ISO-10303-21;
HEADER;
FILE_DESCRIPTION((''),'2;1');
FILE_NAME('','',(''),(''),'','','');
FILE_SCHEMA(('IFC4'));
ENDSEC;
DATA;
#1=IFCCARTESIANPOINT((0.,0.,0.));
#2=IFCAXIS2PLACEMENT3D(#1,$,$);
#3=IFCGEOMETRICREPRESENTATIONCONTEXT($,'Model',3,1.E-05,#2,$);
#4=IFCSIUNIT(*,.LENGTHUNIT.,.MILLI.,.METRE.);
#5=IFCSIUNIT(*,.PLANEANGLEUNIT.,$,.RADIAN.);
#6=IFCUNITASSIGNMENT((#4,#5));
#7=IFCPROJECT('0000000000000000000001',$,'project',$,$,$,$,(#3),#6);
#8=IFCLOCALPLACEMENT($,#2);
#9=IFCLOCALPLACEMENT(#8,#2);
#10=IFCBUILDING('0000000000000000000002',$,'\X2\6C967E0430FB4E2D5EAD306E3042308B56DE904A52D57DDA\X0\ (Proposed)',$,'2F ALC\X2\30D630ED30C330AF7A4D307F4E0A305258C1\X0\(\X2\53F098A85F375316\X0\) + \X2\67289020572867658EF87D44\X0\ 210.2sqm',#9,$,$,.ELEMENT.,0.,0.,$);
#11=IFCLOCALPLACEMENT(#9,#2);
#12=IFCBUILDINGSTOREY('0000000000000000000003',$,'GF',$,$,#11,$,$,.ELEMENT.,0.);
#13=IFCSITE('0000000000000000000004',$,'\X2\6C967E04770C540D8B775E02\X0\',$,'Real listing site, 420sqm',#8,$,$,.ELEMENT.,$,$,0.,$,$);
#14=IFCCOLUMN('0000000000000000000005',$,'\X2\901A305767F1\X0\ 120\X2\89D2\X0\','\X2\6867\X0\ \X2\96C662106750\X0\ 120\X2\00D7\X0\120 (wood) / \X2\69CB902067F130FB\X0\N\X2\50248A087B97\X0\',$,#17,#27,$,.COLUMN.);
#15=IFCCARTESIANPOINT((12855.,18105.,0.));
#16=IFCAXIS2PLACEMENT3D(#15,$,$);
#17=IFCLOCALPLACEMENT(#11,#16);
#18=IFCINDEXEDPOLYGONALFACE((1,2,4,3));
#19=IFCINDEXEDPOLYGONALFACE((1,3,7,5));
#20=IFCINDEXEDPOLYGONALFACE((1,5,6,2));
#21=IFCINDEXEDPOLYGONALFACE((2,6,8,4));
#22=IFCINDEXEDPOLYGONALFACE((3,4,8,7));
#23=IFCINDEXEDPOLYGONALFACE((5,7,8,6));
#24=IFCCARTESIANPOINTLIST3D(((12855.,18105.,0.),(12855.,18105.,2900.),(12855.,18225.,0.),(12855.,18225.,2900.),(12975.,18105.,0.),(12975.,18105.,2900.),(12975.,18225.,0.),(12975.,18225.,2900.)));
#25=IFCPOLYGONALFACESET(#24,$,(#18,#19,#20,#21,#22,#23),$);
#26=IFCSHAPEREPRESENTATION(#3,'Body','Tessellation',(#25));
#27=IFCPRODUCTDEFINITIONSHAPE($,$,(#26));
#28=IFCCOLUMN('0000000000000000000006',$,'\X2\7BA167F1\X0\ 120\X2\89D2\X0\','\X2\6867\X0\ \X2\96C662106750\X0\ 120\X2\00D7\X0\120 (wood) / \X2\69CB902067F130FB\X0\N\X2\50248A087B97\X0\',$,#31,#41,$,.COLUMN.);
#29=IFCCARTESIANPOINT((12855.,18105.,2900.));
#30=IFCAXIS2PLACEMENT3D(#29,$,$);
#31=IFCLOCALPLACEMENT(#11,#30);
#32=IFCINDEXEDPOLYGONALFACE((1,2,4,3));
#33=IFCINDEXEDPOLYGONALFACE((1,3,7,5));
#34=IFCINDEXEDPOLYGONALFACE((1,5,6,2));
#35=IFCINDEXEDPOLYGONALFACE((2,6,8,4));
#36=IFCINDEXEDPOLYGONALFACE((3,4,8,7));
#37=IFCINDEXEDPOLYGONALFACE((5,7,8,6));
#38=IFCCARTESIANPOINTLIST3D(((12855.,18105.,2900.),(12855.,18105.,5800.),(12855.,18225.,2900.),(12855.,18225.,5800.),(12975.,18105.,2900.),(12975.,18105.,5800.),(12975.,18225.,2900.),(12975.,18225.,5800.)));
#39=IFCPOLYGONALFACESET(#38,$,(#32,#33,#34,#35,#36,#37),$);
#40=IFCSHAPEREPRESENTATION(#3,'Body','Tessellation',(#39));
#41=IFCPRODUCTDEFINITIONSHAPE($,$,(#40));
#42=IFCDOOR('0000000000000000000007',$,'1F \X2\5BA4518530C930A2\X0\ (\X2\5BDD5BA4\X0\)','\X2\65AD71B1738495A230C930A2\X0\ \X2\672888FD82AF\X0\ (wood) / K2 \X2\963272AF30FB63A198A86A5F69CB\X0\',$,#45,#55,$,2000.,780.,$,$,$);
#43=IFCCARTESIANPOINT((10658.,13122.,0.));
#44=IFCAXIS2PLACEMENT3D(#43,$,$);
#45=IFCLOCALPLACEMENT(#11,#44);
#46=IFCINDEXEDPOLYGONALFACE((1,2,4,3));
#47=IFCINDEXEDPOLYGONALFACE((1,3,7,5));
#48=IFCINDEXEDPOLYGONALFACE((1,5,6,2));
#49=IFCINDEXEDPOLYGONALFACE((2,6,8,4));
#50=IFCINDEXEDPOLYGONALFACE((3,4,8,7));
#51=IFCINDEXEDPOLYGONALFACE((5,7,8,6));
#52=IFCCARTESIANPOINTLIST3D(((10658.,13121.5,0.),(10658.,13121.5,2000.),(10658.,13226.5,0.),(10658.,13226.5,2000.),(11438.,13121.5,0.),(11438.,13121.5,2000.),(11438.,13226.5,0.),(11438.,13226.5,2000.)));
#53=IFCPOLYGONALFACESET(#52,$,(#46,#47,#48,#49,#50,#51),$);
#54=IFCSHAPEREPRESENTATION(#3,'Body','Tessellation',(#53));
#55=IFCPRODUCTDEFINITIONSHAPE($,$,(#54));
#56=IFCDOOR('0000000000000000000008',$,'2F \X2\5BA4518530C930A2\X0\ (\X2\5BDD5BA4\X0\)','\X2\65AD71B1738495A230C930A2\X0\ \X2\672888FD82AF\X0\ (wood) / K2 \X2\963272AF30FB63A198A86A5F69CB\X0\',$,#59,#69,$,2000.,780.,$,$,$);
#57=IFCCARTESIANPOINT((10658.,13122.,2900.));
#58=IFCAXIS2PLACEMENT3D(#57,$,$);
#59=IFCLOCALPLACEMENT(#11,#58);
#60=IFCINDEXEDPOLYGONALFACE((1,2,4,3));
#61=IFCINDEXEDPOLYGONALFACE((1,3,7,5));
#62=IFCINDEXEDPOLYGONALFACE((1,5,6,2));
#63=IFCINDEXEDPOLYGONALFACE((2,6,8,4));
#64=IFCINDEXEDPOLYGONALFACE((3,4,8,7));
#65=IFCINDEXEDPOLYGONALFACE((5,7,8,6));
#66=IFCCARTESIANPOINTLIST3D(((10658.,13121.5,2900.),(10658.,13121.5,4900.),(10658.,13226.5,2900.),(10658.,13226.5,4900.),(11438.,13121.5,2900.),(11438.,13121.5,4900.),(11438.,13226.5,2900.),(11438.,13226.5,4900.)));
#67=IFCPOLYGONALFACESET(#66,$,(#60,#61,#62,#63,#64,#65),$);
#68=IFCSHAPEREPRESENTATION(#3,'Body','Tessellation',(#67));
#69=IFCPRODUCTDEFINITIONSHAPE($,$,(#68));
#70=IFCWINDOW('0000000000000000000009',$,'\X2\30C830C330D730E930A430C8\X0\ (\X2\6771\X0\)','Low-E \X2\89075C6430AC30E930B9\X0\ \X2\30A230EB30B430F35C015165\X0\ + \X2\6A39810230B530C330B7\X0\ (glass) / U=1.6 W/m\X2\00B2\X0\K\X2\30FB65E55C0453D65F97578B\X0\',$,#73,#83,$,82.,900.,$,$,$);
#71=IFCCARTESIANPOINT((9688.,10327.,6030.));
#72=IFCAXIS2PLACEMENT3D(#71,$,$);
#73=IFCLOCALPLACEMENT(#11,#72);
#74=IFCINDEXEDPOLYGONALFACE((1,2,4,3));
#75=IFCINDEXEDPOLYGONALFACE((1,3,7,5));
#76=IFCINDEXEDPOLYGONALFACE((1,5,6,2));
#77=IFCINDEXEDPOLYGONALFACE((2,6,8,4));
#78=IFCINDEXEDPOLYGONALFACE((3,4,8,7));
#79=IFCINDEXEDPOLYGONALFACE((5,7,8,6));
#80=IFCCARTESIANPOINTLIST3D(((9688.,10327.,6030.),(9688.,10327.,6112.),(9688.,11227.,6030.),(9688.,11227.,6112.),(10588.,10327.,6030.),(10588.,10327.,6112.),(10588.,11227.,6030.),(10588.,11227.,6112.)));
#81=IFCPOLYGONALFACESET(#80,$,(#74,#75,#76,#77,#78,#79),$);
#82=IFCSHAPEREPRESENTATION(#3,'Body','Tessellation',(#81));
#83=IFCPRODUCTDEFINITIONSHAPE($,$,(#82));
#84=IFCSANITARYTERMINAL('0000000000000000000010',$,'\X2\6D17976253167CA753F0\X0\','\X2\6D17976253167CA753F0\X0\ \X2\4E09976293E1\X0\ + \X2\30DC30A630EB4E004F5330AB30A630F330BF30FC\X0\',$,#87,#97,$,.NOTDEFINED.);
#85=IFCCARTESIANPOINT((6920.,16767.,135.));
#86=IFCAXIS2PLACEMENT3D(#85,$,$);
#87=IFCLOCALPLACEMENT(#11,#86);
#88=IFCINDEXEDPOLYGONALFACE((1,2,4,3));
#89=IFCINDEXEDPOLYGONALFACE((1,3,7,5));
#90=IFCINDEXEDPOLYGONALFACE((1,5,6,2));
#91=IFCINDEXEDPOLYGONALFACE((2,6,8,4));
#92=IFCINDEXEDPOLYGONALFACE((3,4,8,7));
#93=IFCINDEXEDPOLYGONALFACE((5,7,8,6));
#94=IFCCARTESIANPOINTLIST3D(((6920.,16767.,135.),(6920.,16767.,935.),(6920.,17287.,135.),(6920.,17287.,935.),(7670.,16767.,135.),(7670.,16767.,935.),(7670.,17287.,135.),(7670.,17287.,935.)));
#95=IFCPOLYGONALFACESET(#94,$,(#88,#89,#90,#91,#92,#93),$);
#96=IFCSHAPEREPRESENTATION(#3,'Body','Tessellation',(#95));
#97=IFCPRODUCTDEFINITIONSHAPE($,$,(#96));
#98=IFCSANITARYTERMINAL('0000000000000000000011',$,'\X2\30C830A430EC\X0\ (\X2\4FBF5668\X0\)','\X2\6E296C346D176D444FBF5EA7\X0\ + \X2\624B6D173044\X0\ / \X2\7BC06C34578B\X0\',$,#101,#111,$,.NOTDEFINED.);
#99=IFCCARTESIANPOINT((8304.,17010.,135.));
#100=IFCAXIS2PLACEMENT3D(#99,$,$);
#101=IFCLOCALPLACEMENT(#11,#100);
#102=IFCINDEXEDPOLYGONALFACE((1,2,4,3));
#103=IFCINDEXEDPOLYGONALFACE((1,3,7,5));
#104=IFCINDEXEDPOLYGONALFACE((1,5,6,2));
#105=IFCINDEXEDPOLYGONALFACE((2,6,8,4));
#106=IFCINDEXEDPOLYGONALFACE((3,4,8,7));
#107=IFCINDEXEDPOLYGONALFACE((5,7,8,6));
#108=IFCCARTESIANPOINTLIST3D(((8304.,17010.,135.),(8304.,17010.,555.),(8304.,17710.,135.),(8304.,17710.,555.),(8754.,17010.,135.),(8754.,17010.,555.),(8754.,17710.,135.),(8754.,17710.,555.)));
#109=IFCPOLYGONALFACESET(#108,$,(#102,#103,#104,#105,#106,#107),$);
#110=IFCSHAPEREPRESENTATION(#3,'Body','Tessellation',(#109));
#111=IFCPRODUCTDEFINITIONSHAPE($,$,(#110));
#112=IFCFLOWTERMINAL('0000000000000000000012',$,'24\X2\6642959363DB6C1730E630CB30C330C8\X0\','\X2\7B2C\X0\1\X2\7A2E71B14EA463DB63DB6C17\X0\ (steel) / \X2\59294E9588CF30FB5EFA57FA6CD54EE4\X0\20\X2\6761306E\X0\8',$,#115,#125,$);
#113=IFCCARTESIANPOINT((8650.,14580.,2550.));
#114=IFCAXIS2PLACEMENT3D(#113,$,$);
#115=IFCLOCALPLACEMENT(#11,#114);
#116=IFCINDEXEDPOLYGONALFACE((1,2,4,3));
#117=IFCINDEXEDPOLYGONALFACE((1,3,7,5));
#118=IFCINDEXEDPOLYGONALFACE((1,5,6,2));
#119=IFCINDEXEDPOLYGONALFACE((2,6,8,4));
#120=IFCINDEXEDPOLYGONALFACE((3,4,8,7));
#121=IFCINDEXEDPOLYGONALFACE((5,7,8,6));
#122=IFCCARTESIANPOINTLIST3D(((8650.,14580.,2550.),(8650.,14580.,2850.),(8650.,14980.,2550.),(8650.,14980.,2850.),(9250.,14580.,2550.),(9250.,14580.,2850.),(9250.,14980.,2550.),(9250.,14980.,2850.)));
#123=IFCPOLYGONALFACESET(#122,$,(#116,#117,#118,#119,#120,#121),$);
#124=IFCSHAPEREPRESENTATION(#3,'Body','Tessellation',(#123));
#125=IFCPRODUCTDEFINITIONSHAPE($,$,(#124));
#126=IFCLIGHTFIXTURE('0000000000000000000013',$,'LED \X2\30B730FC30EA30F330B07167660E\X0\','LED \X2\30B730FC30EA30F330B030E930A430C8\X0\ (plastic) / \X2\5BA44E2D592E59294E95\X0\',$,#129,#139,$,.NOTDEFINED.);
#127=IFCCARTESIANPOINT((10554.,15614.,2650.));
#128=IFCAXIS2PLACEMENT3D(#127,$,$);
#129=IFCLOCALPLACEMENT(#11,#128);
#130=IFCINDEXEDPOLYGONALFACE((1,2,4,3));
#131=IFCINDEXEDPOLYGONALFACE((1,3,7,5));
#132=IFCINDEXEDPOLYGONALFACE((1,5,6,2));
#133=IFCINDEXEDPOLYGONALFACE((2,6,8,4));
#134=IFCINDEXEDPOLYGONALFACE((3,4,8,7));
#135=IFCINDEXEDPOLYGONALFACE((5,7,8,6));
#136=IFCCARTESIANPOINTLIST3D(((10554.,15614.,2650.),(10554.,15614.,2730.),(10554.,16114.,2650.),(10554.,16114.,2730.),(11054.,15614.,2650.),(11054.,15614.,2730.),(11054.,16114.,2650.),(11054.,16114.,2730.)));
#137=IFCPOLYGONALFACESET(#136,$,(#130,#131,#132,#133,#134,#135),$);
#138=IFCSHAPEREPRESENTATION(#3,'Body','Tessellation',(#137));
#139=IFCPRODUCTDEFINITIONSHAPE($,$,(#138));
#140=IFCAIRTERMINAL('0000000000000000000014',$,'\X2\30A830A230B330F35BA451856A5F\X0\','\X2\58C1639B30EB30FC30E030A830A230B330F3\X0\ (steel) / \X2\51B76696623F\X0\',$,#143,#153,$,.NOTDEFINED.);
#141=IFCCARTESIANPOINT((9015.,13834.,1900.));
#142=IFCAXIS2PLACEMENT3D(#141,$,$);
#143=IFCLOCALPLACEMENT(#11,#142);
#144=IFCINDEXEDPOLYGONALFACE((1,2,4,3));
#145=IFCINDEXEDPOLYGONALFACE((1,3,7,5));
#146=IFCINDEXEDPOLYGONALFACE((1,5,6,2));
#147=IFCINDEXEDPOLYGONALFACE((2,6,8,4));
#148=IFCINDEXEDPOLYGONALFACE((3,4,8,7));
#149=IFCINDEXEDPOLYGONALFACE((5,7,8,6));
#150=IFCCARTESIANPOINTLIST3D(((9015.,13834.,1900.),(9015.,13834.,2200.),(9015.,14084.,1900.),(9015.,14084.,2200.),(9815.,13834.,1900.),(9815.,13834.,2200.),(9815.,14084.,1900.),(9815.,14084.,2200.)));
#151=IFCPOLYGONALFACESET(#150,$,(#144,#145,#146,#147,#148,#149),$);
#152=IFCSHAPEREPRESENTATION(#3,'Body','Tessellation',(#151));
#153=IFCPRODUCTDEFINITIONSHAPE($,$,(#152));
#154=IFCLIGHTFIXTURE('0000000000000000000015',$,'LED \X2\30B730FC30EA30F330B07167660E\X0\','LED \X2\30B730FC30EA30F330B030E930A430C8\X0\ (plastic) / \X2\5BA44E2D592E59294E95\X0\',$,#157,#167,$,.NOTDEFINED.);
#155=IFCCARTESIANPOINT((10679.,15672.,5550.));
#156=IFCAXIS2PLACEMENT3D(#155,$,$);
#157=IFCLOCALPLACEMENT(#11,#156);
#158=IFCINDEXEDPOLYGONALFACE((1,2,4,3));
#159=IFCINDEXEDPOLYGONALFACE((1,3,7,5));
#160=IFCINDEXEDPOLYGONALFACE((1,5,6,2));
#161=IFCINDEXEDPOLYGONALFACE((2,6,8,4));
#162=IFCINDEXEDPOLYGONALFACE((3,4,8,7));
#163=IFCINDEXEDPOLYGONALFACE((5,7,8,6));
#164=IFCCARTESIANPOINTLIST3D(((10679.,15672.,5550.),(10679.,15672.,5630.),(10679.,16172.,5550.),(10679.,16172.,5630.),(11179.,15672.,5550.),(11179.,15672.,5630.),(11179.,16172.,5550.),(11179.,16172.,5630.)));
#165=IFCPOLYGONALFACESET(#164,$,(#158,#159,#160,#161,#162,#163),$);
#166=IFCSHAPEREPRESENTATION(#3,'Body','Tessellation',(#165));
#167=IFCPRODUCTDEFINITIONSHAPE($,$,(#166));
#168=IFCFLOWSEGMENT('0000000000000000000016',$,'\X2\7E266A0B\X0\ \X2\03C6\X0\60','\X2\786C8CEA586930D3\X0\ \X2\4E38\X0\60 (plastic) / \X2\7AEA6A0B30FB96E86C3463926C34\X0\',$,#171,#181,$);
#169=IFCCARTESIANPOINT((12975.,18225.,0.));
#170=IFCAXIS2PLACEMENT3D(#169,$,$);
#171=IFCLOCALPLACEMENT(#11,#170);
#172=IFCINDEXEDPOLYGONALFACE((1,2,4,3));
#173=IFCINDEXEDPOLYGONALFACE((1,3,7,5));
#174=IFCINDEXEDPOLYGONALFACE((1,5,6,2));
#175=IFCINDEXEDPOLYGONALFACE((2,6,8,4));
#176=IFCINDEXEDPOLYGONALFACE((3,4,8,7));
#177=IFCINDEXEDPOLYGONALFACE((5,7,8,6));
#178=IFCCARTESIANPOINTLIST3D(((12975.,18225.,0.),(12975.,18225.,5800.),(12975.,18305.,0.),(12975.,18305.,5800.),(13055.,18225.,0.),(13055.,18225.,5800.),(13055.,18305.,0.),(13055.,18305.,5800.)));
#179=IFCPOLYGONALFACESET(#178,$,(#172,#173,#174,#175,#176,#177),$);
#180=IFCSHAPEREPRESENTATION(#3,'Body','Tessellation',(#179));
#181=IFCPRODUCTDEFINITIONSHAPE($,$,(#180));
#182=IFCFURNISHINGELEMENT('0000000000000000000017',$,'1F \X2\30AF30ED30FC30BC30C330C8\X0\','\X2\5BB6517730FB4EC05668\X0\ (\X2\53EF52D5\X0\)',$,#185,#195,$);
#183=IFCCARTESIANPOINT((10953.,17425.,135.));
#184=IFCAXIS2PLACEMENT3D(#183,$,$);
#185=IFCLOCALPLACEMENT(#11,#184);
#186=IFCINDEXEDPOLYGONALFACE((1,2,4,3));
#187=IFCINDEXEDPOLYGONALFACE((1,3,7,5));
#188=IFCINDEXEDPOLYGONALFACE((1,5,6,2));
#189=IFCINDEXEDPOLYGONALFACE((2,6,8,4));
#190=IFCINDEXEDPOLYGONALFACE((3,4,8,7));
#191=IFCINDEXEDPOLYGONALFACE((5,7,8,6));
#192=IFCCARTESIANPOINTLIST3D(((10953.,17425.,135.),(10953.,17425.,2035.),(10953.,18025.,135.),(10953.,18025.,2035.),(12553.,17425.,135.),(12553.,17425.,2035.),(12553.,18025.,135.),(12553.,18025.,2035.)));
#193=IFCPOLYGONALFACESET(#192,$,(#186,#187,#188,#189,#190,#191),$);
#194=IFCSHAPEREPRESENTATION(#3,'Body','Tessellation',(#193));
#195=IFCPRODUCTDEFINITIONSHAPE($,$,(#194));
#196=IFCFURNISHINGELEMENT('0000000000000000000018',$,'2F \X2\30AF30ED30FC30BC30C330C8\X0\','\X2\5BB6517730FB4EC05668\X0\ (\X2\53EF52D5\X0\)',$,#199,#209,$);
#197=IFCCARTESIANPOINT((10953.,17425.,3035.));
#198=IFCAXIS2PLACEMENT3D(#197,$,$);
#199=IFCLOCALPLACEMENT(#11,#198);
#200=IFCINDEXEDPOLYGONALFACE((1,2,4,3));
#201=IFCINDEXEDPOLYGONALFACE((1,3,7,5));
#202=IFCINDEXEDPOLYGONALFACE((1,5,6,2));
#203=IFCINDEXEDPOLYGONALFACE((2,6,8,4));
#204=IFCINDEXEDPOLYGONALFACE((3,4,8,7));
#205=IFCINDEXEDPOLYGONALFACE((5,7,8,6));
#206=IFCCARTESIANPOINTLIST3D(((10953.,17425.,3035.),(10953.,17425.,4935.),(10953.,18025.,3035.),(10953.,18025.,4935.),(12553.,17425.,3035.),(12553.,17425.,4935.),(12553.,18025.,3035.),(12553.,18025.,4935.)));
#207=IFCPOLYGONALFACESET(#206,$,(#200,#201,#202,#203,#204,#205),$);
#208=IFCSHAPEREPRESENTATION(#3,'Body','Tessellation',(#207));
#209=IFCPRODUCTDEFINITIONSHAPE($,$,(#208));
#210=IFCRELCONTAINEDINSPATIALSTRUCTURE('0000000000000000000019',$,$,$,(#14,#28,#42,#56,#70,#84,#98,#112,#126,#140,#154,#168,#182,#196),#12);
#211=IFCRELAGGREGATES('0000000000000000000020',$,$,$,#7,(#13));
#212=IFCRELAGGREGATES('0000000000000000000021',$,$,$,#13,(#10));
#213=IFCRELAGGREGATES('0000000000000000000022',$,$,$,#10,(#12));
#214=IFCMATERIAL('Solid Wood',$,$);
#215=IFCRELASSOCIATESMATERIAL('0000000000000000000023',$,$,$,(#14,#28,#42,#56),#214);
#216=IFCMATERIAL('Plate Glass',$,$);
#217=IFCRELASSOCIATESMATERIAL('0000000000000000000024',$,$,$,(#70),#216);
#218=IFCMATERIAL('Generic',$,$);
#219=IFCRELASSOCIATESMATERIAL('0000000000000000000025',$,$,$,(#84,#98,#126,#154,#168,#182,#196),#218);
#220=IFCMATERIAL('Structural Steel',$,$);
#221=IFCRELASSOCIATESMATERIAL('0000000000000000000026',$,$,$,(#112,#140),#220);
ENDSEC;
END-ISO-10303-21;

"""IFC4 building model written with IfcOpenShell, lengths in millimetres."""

from ifc_helpers import new_model, si_unit, frame, frame_2d, origin, place, context, project, spatial, rectangle, extrude, material, element, save


model = new_model("IFC4")

# Units and contexts
model_context = context("Model", 3, precision=1e-05, world=origin())
ifc_project = project(units=[si_unit("LENGTHUNIT", "METRE", prefix="MILLI"), si_unit("PLANEANGLEUNIT", "RADIAN")], contexts=[model_context])

# Site, building, storey
site_placement = place(None, origin())
site = spatial("IfcSite", under=ifc_project, at=site_placement, Name="沖縄県名護市", ObjectType="Real listing site, 420sqm", CompositionType="ELEMENT", RefElevation=0.0)
building_placement = place(site_placement, origin())
building = spatial("IfcBuilding", under=site, at=building_placement, Name="沖縄・中庭のある回遊動線 (Proposed)", ObjectType="2F ALCブロック積み上げ壁(台風強化) + 木造在来軸組 210.2sqm", CompositionType="ELEMENT", ElevationOfRefHeight=0.0, ElevationOfTerrain=0.0)
storey_placement = place(building_placement, origin())
storey = spatial("IfcBuildingStorey", under=building, at=storey_placement, Name="GF", CompositionType="ELEMENT", Elevation=0.0)

# Columns
ifc_material_1 = material(Name="Solid Wood")
column_1_placement = place(storey_placement, frame((12855.0, 18105.0, 0.0)))
element("IfcColumn", 1, at=column_1_placement, inside=storey, material=ifc_material_1, Name="通し柱 120角", Description="桧 集成材 120×120 (wood) / 構造柱・N値計算", PredefinedType="COLUMN", context=model_context, shape_type="SweptSolid", body=[
    extrude(rectangle(XDim=120.0, YDim=120.0, at=frame_2d((60.0, 60.0))), frame((12855.0, 18105.0, 0.0)), (0.0, 0.0, 1.0), 2900.0),
])
column_2_placement = place(storey_placement, frame((12855.0, 18105.0, 2900.0)))
element("IfcColumn", 2, at=column_2_placement, inside=storey, material=ifc_material_1, Name="管柱 120角", Description="桧 集成材 120×120 (wood) / 構造柱・N値計算", PredefinedType="COLUMN", context=model_context, shape_type="SweptSolid", body=[
    extrude(rectangle(XDim=120.0, YDim=120.0, at=frame_2d((60.0, 60.0))), frame((12855.0, 18105.0, 2900.0)), (0.0, 0.0, 1.0), 2900.0),
])

# Door
door_1_placement = place(storey_placement, frame((10658.0, 13122.0, 0.0)))
element("IfcDoor", 3, at=door_1_placement, inside=storey, material=ifc_material_1, Name="1F 室内ドア (寝室)", Description="断熱玄関ドア 木製芯 (wood) / K2 防犯・採風機構", OverallHeight=2000.0, OverallWidth=780.0, context=model_context, shape_type="SweptSolid", body=[
    extrude(rectangle(XDim=780.0, YDim=105.0, at=frame_2d((390.0, 52.0))), frame((10658.0, 13122.0, 0.0)), (0.0, 0.0, 1.0), 2000.0),
])

# Door
door_2_placement = place(storey_placement, frame((10658.0, 13122.0, 2900.0)))
element("IfcDoor", 4, at=door_2_placement, inside=storey, material=ifc_material_1, Name="2F 室内ドア (寝室)", Description="断熱玄関ドア 木製芯 (wood) / K2 防犯・採風機構", OverallHeight=2000.0, OverallWidth=780.0, context=model_context, shape_type="SweptSolid", body=[
    extrude(rectangle(XDim=780.0, YDim=105.0, at=frame_2d((390.0, 52.0))), frame((10658.0, 13122.0, 2900.0)), (0.0, 0.0, 1.0), 2000.0),
])

# Window
ifc_material_2 = material(Name="Plate Glass")
window_placement = place(storey_placement, frame((9688.0, 10327.0, 6030.0)))
element("IfcWindow", 5, at=window_placement, inside=storey, material=ifc_material_2, Name="トップライト (東)", Description="Low-E 複層ガラス アルゴン封入 + 樹脂サッシ (glass) / U=1.6 W/m²K・日射取得型", OverallHeight=82.0, OverallWidth=900.0, context=model_context, shape_type="SweptSolid", body=[
    extrude(rectangle(XDim=900.0, YDim=900.0, at=frame_2d((450.0, 450.0))), frame((9688.0, 10327.0, 6030.0)), (0.0, 0.0, 1.0), 82.0),
])

# Sanitary terminals
ifc_material_3 = material(Name="Generic")
sanitary_terminal_1_placement = place(storey_placement, frame((6920.0, 16767.0, 135.0)))
element("IfcSanitaryTerminal", 6, at=sanitary_terminal_1_placement, inside=storey, material=ifc_material_3, Name="洗面化粧台", Description="洗面化粧台 三面鏡 + ボウル一体カウンター", PredefinedType="NOTDEFINED", context=model_context, shape_type="SweptSolid", body=[
    extrude(rectangle(XDim=750.0, YDim=520.0, at=frame_2d((375.0, 260.0))), frame((6920.0, 16767.0, 135.0)), (0.0, 0.0, 1.0), 800.0),
])
sanitary_terminal_2_placement = place(storey_placement, frame((8304.0, 17010.0, 135.0)))
element("IfcSanitaryTerminal", 7, at=sanitary_terminal_2_placement, inside=storey, material=ifc_material_3, Name="トイレ (便器)", Description="温水洗浄便座 + 手洗い / 節水型", PredefinedType="NOTDEFINED", context=model_context, shape_type="SweptSolid", body=[
    extrude(rectangle(XDim=450.0, YDim=700.0, at=frame_2d((225.0, 350.0))), frame((8304.0, 17010.0, 135.0)), (0.0, 0.0, 1.0), 420.0),
])

# Flow terminal
ifc_material_4 = material(Name="Structural Steel")
flow_terminal_placement = place(storey_placement, frame((8650.0, 14580.0, 2550.0)))
element("IfcFlowTerminal", 8, at=flow_terminal_placement, inside=storey, material=ifc_material_4, Name="24時間換気ユニット", Description="第1種熱交換換気 (steel) / 天井裏・建基法令20条の8", context=model_context, shape_type="SweptSolid", body=[
    extrude(rectangle(XDim=600.0, YDim=400.0, at=frame_2d((300.0, 200.0))), frame((8650.0, 14580.0, 2550.0)), (0.0, 0.0, 1.0), 300.0),
])

# Light fixture
light_fixture_1_placement = place(storey_placement, frame((10554.0, 15614.0, 2650.0)))
element("IfcLightFixture", 9, at=light_fixture_1_placement, inside=storey, material=ifc_material_3, Name="LED シーリング照明", Description="LED シーリングライト (plastic) / 室中央天井", PredefinedType="NOTDEFINED", context=model_context, shape_type="SweptSolid", body=[
    extrude(rectangle(XDim=500.0, YDim=500.0, at=frame_2d((250.0, 250.0))), frame((10554.0, 15614.0, 2650.0)), (0.0, 0.0, 1.0), 80.0),
])

# Air terminal
air_terminal_placement = place(storey_placement, frame((9015.0, 13834.0, 1900.0)))
element("IfcAirTerminal", 10, at=air_terminal_placement, inside=storey, material=ifc_material_4, Name="エアコン室内機", Description="壁掛ルームエアコン (steel) / 冷暖房", PredefinedType="NOTDEFINED", context=model_context, shape_type="SweptSolid", body=[
    extrude(rectangle(XDim=800.0, YDim=250.0, at=frame_2d((400.0, 125.0))), frame((9015.0, 13834.0, 1900.0)), (0.0, 0.0, 1.0), 300.0),
])

# Light fixture
light_fixture_2_placement = place(storey_placement, frame((10679.0, 15672.0, 5550.0)))
element("IfcLightFixture", 11, at=light_fixture_2_placement, inside=storey, material=ifc_material_3, Name="LED シーリング照明", Description="LED シーリングライト (plastic) / 室中央天井", PredefinedType="NOTDEFINED", context=model_context, shape_type="SweptSolid", body=[
    extrude(rectangle(XDim=500.0, YDim=500.0, at=frame_2d((250.0, 250.0))), frame((10679.0, 15672.0, 5550.0)), (0.0, 0.0, 1.0), 80.0),
])

# Flow segment
flow_segment_placement = place(storey_placement, frame((12975.0, 18225.0, 0.0)))
element("IfcFlowSegment", 12, at=flow_segment_placement, inside=storey, material=ifc_material_3, Name="縦樋 φ60", Description="硬質塩ビ 丸60 (plastic) / 竪樋・雨水排水", context=model_context, shape_type="SweptSolid", body=[
    extrude(rectangle(XDim=80.0, YDim=80.0, at=frame_2d((40.0, 40.0))), frame((12975.0, 18225.0, 0.0)), (0.0, 0.0, 1.0), 5800.0),
])

# Furnishing elements
furnishing_1_placement = place(storey_placement, frame((10953.0, 17425.0, 135.0)))
element("IfcFurnishingElement", 13, at=furnishing_1_placement, inside=storey, material=ifc_material_3, Name="1F クローゼット", Description="家具・什器 (可動)", context=model_context, shape_type="SweptSolid", body=[
    extrude(rectangle(XDim=1600.0, YDim=600.0, at=frame_2d((800.0, 300.0))), frame((10953.0, 17425.0, 135.0)), (0.0, 0.0, 1.0), 1900.0),
])
furnishing_2_placement = place(storey_placement, frame((10953.0, 17425.0, 3035.0)))
element("IfcFurnishingElement", 14, at=furnishing_2_placement, inside=storey, material=ifc_material_3, Name="2F クローゼット", Description="家具・什器 (可動)", context=model_context, shape_type="SweptSolid", body=[
    extrude(rectangle(XDim=1600.0, YDim=600.0, at=frame_2d((800.0, 300.0))), frame((10953.0, 17425.0, 3035.0)), (0.0, 0.0, 1.0), 1900.0),
])

save(model, "model.ifc")
